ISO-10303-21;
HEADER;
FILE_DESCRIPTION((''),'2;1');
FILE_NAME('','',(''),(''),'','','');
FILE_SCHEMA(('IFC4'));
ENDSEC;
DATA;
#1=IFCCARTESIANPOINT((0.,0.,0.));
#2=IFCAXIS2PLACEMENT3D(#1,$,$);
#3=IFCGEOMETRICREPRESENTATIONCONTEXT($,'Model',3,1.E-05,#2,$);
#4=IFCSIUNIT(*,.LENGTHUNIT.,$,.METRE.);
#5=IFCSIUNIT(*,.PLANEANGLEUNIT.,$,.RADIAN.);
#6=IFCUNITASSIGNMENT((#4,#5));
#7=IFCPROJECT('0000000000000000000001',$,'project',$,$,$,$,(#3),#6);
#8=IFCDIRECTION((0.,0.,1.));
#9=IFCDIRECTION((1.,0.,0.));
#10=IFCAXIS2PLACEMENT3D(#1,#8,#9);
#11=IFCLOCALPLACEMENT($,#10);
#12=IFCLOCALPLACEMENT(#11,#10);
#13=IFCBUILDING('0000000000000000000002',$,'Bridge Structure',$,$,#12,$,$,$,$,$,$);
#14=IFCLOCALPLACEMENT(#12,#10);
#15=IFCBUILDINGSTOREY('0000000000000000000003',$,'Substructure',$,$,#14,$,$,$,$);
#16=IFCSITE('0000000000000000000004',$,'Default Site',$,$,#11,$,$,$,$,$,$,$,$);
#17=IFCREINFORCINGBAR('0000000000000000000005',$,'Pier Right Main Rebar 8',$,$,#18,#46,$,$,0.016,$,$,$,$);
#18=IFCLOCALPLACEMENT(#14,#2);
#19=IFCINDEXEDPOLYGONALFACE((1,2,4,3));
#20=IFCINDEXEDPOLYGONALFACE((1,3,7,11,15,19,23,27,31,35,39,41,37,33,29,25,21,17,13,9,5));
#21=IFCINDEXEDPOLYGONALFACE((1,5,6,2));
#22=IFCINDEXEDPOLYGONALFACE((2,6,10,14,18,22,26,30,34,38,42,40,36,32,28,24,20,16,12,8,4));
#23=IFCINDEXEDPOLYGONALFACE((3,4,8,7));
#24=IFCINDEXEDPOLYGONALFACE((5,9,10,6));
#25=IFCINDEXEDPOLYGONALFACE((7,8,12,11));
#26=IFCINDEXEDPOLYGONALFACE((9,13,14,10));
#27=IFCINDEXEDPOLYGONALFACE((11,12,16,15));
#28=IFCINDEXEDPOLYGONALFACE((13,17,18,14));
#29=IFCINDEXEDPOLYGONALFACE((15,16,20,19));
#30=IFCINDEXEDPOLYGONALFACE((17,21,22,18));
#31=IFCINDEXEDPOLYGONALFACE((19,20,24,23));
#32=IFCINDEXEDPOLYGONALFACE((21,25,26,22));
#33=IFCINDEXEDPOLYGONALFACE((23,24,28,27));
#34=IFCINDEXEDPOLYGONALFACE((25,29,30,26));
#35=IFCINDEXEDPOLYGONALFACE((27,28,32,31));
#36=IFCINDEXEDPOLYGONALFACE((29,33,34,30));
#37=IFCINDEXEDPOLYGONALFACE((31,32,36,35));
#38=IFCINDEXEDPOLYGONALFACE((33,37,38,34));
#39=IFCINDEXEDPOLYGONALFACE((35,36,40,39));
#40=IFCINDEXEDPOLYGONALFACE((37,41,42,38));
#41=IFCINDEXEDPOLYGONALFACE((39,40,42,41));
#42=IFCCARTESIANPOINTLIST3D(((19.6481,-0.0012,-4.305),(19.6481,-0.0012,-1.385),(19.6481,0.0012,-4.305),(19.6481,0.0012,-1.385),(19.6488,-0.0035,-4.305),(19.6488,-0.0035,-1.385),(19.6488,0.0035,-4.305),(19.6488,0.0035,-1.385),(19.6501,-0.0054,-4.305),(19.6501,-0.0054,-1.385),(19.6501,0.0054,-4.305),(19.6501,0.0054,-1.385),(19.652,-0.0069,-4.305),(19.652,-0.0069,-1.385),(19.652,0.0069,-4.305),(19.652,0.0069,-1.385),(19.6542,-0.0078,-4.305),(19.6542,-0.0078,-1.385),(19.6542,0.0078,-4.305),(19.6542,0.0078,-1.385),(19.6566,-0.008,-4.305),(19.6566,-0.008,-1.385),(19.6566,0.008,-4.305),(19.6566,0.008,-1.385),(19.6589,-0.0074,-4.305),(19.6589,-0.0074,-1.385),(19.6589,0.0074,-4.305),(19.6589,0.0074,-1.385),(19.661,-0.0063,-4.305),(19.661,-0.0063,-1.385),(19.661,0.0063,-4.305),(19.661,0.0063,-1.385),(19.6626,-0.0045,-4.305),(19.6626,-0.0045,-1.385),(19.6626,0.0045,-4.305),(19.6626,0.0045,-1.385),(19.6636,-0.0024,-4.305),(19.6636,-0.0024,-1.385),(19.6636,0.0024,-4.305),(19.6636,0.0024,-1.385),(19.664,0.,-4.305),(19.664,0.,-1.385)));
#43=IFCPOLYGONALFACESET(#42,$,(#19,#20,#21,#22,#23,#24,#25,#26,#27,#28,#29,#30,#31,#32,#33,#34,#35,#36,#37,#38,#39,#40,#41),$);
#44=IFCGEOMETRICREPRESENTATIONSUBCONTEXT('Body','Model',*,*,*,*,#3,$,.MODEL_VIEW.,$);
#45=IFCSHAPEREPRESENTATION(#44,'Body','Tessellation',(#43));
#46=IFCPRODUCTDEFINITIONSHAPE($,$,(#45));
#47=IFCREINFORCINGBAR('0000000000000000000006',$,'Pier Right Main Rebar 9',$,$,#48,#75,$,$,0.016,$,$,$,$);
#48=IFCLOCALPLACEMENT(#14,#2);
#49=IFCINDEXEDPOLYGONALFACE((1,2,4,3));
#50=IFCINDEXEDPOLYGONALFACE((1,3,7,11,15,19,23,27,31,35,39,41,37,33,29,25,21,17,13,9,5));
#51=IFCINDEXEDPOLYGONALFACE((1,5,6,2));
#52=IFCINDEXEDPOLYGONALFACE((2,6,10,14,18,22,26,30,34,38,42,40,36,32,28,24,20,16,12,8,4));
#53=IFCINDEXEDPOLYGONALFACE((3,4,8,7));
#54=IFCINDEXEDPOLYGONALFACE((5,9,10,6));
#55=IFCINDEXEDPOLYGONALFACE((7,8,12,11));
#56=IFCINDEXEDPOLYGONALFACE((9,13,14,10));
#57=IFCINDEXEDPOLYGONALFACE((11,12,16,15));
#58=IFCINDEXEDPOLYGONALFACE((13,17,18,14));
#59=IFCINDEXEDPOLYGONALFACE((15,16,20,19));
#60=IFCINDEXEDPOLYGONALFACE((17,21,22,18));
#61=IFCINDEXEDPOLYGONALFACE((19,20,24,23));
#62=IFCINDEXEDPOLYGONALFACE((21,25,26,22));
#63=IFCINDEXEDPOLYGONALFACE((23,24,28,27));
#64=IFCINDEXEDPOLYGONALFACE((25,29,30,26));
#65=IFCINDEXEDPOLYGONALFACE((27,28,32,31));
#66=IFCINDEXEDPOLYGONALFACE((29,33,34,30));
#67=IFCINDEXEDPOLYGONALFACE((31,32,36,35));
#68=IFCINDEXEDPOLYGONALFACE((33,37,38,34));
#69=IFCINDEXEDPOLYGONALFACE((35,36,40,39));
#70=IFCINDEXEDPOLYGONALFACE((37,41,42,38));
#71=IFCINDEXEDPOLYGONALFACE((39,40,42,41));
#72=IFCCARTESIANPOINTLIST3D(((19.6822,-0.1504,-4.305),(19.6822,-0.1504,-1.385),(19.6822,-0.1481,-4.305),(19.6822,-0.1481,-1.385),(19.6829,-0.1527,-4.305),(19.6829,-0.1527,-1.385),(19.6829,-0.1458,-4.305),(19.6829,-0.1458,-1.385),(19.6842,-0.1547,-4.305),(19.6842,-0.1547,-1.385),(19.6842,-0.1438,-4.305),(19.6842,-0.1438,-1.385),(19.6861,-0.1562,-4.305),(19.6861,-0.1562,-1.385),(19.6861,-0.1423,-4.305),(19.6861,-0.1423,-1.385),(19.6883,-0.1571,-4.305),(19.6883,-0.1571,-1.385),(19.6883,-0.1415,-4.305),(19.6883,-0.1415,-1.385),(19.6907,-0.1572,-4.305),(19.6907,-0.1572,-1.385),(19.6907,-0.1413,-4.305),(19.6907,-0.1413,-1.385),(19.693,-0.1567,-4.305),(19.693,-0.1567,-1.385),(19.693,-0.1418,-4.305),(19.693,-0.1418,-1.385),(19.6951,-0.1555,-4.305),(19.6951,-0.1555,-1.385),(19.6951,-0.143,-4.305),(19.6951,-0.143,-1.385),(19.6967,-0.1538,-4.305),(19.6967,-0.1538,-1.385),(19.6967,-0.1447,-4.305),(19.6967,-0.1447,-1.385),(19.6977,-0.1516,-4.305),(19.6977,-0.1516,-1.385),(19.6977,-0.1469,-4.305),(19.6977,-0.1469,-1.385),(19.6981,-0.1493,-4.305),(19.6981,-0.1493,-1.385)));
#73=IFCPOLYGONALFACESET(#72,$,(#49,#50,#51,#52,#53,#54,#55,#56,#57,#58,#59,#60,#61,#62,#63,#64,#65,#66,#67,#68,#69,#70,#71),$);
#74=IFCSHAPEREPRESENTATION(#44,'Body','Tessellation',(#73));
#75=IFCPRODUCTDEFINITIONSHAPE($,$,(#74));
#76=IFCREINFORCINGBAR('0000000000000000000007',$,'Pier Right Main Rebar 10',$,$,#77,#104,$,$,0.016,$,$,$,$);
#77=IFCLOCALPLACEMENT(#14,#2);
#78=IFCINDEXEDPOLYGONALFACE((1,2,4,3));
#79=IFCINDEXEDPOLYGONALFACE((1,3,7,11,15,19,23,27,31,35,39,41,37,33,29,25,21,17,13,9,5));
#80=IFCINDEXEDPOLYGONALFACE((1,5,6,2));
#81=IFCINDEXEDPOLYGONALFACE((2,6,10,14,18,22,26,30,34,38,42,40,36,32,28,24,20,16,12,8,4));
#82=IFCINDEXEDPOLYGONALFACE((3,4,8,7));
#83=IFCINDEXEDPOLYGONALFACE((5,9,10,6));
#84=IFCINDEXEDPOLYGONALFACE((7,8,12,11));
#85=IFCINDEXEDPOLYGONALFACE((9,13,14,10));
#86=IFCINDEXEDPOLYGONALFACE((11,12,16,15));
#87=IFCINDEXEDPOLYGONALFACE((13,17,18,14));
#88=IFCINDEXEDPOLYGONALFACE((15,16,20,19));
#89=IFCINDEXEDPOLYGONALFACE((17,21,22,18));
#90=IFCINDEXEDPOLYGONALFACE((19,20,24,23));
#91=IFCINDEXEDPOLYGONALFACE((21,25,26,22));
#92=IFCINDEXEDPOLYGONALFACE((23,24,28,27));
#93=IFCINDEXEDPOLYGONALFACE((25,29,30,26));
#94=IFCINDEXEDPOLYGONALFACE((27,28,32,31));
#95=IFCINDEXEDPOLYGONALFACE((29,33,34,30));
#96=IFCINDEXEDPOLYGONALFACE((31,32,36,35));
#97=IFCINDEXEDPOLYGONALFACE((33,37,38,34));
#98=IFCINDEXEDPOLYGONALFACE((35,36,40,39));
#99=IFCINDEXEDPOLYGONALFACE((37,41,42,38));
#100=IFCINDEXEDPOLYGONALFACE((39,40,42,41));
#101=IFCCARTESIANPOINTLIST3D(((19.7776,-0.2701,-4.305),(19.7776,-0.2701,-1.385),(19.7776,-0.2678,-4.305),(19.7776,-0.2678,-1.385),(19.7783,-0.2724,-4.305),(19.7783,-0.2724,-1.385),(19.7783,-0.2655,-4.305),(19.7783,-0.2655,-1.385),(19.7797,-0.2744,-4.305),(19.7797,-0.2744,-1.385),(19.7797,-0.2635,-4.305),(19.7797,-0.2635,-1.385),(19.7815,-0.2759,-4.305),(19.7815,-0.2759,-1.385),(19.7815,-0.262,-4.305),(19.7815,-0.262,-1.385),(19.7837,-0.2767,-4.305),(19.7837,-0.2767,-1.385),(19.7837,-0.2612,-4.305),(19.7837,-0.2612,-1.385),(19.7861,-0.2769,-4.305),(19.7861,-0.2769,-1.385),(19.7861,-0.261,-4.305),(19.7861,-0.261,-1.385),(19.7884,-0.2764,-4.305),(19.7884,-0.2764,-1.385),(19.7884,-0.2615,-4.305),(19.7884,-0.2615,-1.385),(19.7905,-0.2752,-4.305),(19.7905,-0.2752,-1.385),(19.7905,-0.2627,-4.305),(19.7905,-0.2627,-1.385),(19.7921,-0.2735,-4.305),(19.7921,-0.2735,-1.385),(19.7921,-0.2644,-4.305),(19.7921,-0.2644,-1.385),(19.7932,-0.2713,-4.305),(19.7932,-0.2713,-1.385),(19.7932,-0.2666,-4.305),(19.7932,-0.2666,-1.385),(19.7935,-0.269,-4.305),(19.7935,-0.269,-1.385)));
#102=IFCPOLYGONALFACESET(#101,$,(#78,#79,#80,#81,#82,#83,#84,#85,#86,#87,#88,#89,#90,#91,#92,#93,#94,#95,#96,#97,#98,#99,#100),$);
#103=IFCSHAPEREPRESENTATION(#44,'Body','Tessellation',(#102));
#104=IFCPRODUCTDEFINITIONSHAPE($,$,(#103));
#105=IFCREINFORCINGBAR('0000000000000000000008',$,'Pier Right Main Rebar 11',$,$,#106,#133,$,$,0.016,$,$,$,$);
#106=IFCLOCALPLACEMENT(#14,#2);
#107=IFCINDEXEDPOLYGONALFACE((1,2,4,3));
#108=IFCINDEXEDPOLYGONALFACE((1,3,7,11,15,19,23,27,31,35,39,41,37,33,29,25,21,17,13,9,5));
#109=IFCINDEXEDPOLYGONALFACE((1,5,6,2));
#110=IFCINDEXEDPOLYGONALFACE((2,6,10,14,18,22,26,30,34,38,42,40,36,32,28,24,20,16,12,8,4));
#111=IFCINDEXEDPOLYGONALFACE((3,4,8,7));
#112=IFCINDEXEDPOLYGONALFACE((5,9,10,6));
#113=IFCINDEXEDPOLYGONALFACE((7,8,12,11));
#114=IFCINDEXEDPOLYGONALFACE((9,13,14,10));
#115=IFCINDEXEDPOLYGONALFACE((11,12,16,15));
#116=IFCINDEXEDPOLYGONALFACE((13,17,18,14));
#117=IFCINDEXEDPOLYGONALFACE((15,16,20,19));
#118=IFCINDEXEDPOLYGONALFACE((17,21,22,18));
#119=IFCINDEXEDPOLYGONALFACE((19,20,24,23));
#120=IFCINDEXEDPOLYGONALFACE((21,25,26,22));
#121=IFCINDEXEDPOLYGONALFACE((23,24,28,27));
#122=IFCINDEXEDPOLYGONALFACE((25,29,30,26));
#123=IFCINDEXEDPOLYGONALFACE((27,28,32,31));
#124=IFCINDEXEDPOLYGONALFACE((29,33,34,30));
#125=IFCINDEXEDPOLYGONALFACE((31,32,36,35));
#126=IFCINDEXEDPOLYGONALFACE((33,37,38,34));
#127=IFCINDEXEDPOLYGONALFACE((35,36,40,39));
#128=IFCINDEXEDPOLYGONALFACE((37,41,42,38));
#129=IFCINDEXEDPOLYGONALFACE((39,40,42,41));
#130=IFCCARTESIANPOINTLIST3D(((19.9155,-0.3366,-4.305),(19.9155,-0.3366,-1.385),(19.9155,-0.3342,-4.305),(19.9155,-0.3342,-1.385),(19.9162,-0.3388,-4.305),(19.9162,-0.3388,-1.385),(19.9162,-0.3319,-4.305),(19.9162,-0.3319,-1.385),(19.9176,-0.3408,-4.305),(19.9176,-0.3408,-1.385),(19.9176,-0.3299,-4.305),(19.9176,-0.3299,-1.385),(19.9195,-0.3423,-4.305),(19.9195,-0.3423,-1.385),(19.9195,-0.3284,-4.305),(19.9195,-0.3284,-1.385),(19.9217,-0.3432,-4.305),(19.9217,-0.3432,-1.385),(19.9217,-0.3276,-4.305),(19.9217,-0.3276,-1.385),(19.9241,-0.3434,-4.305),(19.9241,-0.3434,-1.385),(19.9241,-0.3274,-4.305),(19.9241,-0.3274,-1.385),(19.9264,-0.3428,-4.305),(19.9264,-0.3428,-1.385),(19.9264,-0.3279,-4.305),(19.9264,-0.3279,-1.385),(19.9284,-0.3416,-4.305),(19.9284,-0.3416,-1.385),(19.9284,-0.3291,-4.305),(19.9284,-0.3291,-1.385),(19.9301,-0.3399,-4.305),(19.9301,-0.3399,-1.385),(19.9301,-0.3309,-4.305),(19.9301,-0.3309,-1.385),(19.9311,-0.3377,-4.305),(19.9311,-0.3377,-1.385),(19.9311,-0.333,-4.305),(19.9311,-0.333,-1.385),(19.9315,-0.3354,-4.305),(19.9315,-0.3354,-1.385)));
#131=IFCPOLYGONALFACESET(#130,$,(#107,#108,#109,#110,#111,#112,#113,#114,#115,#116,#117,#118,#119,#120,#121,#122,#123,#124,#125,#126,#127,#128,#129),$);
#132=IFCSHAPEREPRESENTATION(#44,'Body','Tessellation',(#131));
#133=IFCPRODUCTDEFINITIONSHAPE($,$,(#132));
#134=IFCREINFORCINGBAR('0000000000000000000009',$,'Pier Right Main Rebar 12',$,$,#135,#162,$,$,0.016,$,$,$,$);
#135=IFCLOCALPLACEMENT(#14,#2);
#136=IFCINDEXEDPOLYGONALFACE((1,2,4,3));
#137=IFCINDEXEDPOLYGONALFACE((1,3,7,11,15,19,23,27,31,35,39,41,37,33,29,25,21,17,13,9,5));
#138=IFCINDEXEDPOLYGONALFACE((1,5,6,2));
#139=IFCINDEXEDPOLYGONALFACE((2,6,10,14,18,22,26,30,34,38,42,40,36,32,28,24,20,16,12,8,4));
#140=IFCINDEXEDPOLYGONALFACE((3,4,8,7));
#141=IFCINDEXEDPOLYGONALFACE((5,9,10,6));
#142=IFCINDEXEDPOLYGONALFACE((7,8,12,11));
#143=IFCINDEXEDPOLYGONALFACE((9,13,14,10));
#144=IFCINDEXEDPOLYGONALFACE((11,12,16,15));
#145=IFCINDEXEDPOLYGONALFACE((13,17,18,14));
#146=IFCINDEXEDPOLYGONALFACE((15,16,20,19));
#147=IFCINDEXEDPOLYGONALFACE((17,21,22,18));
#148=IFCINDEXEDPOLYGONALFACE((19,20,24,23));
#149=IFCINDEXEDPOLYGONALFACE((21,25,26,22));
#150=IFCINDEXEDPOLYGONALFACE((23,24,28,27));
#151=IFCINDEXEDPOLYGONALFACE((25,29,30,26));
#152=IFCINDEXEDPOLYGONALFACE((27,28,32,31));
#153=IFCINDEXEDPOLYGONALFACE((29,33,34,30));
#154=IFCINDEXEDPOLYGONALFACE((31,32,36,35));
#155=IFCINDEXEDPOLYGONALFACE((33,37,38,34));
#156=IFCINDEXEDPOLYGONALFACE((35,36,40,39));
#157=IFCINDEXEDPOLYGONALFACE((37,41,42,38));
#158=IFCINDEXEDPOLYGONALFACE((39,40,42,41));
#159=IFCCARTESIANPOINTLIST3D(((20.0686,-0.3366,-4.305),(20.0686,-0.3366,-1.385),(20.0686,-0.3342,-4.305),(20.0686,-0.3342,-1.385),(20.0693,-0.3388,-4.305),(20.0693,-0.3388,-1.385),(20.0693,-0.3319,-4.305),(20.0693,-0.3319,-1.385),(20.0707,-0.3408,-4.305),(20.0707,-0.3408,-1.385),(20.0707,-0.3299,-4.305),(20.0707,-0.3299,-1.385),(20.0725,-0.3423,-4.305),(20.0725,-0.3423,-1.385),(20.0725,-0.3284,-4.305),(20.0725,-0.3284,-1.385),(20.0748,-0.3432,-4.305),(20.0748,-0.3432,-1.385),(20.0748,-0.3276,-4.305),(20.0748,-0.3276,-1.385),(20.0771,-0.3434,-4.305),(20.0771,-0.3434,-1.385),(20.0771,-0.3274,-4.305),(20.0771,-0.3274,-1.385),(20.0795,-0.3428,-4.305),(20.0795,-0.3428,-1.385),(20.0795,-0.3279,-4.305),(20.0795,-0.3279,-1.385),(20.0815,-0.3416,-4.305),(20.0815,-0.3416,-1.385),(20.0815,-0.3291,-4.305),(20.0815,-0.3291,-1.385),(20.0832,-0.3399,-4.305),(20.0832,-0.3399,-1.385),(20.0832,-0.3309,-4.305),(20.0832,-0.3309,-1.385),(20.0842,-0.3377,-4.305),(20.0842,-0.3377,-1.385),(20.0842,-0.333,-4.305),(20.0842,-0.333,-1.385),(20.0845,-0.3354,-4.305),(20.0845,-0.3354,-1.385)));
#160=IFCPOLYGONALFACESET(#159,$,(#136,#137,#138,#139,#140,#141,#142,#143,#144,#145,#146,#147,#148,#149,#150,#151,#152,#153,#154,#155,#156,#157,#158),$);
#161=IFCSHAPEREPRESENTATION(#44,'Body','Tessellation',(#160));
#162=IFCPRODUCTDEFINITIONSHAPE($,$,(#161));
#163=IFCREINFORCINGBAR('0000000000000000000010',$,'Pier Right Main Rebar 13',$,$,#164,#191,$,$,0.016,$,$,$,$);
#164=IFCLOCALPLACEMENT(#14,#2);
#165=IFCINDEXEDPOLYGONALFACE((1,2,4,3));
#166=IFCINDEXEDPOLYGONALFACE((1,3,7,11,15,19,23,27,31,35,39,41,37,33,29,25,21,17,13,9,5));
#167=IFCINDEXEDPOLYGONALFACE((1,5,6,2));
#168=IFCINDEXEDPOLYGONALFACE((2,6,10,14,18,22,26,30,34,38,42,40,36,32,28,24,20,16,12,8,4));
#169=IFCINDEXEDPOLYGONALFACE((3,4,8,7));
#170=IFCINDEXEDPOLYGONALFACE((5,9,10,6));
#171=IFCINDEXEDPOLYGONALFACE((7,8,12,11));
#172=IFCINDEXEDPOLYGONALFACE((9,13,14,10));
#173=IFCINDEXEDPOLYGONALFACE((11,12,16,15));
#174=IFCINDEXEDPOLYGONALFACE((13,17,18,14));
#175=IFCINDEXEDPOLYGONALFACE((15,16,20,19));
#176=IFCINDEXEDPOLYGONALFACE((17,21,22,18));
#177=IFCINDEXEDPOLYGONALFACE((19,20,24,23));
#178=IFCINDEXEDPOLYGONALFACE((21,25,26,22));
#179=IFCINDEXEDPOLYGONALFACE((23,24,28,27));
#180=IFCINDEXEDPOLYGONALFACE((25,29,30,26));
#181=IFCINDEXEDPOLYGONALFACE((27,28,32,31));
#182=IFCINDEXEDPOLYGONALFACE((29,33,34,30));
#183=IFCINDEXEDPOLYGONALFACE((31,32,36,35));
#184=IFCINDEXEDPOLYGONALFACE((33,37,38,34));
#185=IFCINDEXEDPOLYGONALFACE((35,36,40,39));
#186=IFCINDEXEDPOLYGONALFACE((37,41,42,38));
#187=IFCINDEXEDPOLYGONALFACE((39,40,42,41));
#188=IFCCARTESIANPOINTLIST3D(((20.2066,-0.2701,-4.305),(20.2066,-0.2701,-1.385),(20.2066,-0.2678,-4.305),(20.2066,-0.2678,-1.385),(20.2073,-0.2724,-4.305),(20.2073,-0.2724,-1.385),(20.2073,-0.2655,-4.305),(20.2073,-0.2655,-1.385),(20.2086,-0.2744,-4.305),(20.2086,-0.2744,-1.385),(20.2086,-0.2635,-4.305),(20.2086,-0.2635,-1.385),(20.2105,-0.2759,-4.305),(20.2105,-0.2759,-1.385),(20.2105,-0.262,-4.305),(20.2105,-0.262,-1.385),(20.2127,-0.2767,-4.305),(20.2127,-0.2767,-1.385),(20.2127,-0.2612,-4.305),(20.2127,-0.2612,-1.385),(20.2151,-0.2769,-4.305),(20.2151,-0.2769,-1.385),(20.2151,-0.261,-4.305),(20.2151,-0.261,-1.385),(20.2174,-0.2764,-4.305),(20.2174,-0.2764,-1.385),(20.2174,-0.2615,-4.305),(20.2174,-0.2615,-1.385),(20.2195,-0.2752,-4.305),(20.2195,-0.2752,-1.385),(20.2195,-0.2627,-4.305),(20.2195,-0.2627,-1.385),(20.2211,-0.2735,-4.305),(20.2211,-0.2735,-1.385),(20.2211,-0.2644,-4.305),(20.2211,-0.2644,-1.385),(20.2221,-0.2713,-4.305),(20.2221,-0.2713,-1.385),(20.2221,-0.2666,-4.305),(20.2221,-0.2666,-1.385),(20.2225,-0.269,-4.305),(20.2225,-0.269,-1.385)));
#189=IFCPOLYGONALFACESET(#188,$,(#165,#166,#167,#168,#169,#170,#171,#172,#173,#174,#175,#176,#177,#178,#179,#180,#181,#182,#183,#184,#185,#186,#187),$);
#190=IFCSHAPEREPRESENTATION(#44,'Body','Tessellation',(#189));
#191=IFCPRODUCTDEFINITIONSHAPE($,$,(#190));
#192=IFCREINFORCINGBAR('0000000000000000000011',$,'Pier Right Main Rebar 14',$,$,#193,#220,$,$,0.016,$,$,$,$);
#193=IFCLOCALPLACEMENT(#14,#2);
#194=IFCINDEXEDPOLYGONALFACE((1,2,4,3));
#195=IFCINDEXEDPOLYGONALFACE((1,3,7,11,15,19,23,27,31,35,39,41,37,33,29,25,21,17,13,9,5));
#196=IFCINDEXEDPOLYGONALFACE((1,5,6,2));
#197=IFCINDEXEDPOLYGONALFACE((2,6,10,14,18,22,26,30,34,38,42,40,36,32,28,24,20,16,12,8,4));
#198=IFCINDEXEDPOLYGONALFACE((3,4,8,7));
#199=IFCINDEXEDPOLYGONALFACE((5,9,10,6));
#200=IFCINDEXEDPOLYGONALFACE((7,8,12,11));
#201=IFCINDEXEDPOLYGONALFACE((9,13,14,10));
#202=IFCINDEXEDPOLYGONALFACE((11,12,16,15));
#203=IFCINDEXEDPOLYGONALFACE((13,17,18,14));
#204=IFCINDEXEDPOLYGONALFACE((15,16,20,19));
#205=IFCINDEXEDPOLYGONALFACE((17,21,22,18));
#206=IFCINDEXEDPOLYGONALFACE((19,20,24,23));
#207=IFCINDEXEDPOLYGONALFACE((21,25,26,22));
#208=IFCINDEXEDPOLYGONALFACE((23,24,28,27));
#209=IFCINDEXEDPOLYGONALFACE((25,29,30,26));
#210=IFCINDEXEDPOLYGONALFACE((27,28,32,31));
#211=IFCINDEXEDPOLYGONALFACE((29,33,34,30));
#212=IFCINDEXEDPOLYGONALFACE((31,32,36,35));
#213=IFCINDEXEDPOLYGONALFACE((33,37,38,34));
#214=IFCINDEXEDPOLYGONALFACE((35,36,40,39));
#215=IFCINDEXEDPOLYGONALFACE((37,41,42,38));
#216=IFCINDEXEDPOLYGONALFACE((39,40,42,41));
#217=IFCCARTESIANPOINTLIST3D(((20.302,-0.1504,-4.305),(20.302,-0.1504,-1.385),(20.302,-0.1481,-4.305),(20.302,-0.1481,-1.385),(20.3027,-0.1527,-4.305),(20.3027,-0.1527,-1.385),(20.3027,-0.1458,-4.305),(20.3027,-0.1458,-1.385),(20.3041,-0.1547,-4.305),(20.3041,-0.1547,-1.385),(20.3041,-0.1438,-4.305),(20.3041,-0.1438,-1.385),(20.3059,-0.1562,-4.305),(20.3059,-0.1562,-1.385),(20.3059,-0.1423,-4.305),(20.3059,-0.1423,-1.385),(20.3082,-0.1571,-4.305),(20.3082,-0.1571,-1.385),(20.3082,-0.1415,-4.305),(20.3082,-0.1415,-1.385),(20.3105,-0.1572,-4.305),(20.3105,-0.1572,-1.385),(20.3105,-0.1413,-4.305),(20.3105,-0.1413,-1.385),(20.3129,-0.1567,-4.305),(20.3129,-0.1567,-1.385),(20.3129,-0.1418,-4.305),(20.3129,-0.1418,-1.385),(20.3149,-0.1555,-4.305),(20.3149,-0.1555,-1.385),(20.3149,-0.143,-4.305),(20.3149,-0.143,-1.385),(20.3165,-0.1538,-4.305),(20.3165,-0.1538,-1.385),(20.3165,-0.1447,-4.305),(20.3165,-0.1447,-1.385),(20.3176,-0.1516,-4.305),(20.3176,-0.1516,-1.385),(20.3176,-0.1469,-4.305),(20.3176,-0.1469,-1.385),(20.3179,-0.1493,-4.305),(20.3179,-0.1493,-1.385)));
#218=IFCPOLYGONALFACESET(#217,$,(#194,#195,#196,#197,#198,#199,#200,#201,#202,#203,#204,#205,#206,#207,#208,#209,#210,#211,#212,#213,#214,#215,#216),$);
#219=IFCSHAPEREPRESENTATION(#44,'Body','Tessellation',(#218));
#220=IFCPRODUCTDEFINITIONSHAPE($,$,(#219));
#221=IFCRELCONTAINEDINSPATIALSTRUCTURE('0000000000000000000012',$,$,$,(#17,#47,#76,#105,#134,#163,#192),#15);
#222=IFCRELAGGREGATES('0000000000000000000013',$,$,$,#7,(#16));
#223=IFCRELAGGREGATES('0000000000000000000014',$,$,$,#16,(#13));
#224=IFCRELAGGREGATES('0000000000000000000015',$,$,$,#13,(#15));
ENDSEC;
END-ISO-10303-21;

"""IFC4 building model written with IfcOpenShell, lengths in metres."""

from ifc_helpers import new_model, si_unit, frame, origin, origin_with_axes, origin_2d_with_axis, place, context, subcontext, project, spatial, circle, extrude, element, save


model = new_model("IFC4")

# Units and contexts
model_context = context("Model", 3, precision=1e-05, world=origin())
body_context = subcontext(model_context, "Body", "Model", "MODEL_VIEW")
ifc_project = project(units=[si_unit("LENGTHUNIT", "METRE"), si_unit("PLANEANGLEUNIT", "RADIAN")], contexts=[model_context])

# Site, building, storey
site_placement = place(None, origin_with_axes())
site = spatial("IfcSite", under=ifc_project, at=site_placement, Name="Default Site")
building_placement = place(site_placement, origin_with_axes())
building = spatial("IfcBuilding", under=site, at=building_placement, Name="Bridge Structure")
storey_placement = place(building_placement, origin_with_axes())
storey = spatial("IfcBuildingStorey", under=building, at=storey_placement, Name="Substructure")

# Reinforcing bars
for number, where, z_axis, x_axis, name in (
    (1, (19.656, 0.0, -4.305), (0.0, 0.0, 1.0), (1.0, 0.0, 0.0), "Pier Right Main Rebar 8"),
    (2, (19.6901, -0.1493, -4.305), (0.0, 0.0, 1.0), (1.0, 0.0, 0.0), "Pier Right Main Rebar 9"),
    (3, (19.7855, -0.269, -4.305), (0.0, 0.0, 1.0), (1.0, 0.0, 0.0), "Pier Right Main Rebar 10"),
    (4, (19.9235, -0.3354, -4.305), (0.0, 0.0, 1.0), (1.0, 0.0, 0.0), "Pier Right Main Rebar 11"),
    (5, (20.0765, -0.3354, -4.305), (0.0, 0.0, 1.0), (1.0, 0.0, 0.0), "Pier Right Main Rebar 12"),
    (6, (20.2145, -0.269, -4.305), (0.0, 0.0, 1.0), (1.0, 0.0, 0.0), "Pier Right Main Rebar 13"),
    (7, (20.3099, -0.1493, -4.305), (0.0, 0.0, 1.0), (1.0, 0.0, 0.0), "Pier Right Main Rebar 14"),
):
    element("IfcReinforcingBar", number, at=place(storey_placement, frame(where, z_axis=z_axis, x_axis=x_axis)), inside=storey, Name=name, NominalDiameter=0.016, context=body_context, shape_type="SweptSolid", body=[
        extrude(circle(Radius=0.008, at=origin_2d_with_axis()), origin_with_axes(), (0.0, 0.0, 1.0), 2.92),
    ])

save(model, "model.ifc")
